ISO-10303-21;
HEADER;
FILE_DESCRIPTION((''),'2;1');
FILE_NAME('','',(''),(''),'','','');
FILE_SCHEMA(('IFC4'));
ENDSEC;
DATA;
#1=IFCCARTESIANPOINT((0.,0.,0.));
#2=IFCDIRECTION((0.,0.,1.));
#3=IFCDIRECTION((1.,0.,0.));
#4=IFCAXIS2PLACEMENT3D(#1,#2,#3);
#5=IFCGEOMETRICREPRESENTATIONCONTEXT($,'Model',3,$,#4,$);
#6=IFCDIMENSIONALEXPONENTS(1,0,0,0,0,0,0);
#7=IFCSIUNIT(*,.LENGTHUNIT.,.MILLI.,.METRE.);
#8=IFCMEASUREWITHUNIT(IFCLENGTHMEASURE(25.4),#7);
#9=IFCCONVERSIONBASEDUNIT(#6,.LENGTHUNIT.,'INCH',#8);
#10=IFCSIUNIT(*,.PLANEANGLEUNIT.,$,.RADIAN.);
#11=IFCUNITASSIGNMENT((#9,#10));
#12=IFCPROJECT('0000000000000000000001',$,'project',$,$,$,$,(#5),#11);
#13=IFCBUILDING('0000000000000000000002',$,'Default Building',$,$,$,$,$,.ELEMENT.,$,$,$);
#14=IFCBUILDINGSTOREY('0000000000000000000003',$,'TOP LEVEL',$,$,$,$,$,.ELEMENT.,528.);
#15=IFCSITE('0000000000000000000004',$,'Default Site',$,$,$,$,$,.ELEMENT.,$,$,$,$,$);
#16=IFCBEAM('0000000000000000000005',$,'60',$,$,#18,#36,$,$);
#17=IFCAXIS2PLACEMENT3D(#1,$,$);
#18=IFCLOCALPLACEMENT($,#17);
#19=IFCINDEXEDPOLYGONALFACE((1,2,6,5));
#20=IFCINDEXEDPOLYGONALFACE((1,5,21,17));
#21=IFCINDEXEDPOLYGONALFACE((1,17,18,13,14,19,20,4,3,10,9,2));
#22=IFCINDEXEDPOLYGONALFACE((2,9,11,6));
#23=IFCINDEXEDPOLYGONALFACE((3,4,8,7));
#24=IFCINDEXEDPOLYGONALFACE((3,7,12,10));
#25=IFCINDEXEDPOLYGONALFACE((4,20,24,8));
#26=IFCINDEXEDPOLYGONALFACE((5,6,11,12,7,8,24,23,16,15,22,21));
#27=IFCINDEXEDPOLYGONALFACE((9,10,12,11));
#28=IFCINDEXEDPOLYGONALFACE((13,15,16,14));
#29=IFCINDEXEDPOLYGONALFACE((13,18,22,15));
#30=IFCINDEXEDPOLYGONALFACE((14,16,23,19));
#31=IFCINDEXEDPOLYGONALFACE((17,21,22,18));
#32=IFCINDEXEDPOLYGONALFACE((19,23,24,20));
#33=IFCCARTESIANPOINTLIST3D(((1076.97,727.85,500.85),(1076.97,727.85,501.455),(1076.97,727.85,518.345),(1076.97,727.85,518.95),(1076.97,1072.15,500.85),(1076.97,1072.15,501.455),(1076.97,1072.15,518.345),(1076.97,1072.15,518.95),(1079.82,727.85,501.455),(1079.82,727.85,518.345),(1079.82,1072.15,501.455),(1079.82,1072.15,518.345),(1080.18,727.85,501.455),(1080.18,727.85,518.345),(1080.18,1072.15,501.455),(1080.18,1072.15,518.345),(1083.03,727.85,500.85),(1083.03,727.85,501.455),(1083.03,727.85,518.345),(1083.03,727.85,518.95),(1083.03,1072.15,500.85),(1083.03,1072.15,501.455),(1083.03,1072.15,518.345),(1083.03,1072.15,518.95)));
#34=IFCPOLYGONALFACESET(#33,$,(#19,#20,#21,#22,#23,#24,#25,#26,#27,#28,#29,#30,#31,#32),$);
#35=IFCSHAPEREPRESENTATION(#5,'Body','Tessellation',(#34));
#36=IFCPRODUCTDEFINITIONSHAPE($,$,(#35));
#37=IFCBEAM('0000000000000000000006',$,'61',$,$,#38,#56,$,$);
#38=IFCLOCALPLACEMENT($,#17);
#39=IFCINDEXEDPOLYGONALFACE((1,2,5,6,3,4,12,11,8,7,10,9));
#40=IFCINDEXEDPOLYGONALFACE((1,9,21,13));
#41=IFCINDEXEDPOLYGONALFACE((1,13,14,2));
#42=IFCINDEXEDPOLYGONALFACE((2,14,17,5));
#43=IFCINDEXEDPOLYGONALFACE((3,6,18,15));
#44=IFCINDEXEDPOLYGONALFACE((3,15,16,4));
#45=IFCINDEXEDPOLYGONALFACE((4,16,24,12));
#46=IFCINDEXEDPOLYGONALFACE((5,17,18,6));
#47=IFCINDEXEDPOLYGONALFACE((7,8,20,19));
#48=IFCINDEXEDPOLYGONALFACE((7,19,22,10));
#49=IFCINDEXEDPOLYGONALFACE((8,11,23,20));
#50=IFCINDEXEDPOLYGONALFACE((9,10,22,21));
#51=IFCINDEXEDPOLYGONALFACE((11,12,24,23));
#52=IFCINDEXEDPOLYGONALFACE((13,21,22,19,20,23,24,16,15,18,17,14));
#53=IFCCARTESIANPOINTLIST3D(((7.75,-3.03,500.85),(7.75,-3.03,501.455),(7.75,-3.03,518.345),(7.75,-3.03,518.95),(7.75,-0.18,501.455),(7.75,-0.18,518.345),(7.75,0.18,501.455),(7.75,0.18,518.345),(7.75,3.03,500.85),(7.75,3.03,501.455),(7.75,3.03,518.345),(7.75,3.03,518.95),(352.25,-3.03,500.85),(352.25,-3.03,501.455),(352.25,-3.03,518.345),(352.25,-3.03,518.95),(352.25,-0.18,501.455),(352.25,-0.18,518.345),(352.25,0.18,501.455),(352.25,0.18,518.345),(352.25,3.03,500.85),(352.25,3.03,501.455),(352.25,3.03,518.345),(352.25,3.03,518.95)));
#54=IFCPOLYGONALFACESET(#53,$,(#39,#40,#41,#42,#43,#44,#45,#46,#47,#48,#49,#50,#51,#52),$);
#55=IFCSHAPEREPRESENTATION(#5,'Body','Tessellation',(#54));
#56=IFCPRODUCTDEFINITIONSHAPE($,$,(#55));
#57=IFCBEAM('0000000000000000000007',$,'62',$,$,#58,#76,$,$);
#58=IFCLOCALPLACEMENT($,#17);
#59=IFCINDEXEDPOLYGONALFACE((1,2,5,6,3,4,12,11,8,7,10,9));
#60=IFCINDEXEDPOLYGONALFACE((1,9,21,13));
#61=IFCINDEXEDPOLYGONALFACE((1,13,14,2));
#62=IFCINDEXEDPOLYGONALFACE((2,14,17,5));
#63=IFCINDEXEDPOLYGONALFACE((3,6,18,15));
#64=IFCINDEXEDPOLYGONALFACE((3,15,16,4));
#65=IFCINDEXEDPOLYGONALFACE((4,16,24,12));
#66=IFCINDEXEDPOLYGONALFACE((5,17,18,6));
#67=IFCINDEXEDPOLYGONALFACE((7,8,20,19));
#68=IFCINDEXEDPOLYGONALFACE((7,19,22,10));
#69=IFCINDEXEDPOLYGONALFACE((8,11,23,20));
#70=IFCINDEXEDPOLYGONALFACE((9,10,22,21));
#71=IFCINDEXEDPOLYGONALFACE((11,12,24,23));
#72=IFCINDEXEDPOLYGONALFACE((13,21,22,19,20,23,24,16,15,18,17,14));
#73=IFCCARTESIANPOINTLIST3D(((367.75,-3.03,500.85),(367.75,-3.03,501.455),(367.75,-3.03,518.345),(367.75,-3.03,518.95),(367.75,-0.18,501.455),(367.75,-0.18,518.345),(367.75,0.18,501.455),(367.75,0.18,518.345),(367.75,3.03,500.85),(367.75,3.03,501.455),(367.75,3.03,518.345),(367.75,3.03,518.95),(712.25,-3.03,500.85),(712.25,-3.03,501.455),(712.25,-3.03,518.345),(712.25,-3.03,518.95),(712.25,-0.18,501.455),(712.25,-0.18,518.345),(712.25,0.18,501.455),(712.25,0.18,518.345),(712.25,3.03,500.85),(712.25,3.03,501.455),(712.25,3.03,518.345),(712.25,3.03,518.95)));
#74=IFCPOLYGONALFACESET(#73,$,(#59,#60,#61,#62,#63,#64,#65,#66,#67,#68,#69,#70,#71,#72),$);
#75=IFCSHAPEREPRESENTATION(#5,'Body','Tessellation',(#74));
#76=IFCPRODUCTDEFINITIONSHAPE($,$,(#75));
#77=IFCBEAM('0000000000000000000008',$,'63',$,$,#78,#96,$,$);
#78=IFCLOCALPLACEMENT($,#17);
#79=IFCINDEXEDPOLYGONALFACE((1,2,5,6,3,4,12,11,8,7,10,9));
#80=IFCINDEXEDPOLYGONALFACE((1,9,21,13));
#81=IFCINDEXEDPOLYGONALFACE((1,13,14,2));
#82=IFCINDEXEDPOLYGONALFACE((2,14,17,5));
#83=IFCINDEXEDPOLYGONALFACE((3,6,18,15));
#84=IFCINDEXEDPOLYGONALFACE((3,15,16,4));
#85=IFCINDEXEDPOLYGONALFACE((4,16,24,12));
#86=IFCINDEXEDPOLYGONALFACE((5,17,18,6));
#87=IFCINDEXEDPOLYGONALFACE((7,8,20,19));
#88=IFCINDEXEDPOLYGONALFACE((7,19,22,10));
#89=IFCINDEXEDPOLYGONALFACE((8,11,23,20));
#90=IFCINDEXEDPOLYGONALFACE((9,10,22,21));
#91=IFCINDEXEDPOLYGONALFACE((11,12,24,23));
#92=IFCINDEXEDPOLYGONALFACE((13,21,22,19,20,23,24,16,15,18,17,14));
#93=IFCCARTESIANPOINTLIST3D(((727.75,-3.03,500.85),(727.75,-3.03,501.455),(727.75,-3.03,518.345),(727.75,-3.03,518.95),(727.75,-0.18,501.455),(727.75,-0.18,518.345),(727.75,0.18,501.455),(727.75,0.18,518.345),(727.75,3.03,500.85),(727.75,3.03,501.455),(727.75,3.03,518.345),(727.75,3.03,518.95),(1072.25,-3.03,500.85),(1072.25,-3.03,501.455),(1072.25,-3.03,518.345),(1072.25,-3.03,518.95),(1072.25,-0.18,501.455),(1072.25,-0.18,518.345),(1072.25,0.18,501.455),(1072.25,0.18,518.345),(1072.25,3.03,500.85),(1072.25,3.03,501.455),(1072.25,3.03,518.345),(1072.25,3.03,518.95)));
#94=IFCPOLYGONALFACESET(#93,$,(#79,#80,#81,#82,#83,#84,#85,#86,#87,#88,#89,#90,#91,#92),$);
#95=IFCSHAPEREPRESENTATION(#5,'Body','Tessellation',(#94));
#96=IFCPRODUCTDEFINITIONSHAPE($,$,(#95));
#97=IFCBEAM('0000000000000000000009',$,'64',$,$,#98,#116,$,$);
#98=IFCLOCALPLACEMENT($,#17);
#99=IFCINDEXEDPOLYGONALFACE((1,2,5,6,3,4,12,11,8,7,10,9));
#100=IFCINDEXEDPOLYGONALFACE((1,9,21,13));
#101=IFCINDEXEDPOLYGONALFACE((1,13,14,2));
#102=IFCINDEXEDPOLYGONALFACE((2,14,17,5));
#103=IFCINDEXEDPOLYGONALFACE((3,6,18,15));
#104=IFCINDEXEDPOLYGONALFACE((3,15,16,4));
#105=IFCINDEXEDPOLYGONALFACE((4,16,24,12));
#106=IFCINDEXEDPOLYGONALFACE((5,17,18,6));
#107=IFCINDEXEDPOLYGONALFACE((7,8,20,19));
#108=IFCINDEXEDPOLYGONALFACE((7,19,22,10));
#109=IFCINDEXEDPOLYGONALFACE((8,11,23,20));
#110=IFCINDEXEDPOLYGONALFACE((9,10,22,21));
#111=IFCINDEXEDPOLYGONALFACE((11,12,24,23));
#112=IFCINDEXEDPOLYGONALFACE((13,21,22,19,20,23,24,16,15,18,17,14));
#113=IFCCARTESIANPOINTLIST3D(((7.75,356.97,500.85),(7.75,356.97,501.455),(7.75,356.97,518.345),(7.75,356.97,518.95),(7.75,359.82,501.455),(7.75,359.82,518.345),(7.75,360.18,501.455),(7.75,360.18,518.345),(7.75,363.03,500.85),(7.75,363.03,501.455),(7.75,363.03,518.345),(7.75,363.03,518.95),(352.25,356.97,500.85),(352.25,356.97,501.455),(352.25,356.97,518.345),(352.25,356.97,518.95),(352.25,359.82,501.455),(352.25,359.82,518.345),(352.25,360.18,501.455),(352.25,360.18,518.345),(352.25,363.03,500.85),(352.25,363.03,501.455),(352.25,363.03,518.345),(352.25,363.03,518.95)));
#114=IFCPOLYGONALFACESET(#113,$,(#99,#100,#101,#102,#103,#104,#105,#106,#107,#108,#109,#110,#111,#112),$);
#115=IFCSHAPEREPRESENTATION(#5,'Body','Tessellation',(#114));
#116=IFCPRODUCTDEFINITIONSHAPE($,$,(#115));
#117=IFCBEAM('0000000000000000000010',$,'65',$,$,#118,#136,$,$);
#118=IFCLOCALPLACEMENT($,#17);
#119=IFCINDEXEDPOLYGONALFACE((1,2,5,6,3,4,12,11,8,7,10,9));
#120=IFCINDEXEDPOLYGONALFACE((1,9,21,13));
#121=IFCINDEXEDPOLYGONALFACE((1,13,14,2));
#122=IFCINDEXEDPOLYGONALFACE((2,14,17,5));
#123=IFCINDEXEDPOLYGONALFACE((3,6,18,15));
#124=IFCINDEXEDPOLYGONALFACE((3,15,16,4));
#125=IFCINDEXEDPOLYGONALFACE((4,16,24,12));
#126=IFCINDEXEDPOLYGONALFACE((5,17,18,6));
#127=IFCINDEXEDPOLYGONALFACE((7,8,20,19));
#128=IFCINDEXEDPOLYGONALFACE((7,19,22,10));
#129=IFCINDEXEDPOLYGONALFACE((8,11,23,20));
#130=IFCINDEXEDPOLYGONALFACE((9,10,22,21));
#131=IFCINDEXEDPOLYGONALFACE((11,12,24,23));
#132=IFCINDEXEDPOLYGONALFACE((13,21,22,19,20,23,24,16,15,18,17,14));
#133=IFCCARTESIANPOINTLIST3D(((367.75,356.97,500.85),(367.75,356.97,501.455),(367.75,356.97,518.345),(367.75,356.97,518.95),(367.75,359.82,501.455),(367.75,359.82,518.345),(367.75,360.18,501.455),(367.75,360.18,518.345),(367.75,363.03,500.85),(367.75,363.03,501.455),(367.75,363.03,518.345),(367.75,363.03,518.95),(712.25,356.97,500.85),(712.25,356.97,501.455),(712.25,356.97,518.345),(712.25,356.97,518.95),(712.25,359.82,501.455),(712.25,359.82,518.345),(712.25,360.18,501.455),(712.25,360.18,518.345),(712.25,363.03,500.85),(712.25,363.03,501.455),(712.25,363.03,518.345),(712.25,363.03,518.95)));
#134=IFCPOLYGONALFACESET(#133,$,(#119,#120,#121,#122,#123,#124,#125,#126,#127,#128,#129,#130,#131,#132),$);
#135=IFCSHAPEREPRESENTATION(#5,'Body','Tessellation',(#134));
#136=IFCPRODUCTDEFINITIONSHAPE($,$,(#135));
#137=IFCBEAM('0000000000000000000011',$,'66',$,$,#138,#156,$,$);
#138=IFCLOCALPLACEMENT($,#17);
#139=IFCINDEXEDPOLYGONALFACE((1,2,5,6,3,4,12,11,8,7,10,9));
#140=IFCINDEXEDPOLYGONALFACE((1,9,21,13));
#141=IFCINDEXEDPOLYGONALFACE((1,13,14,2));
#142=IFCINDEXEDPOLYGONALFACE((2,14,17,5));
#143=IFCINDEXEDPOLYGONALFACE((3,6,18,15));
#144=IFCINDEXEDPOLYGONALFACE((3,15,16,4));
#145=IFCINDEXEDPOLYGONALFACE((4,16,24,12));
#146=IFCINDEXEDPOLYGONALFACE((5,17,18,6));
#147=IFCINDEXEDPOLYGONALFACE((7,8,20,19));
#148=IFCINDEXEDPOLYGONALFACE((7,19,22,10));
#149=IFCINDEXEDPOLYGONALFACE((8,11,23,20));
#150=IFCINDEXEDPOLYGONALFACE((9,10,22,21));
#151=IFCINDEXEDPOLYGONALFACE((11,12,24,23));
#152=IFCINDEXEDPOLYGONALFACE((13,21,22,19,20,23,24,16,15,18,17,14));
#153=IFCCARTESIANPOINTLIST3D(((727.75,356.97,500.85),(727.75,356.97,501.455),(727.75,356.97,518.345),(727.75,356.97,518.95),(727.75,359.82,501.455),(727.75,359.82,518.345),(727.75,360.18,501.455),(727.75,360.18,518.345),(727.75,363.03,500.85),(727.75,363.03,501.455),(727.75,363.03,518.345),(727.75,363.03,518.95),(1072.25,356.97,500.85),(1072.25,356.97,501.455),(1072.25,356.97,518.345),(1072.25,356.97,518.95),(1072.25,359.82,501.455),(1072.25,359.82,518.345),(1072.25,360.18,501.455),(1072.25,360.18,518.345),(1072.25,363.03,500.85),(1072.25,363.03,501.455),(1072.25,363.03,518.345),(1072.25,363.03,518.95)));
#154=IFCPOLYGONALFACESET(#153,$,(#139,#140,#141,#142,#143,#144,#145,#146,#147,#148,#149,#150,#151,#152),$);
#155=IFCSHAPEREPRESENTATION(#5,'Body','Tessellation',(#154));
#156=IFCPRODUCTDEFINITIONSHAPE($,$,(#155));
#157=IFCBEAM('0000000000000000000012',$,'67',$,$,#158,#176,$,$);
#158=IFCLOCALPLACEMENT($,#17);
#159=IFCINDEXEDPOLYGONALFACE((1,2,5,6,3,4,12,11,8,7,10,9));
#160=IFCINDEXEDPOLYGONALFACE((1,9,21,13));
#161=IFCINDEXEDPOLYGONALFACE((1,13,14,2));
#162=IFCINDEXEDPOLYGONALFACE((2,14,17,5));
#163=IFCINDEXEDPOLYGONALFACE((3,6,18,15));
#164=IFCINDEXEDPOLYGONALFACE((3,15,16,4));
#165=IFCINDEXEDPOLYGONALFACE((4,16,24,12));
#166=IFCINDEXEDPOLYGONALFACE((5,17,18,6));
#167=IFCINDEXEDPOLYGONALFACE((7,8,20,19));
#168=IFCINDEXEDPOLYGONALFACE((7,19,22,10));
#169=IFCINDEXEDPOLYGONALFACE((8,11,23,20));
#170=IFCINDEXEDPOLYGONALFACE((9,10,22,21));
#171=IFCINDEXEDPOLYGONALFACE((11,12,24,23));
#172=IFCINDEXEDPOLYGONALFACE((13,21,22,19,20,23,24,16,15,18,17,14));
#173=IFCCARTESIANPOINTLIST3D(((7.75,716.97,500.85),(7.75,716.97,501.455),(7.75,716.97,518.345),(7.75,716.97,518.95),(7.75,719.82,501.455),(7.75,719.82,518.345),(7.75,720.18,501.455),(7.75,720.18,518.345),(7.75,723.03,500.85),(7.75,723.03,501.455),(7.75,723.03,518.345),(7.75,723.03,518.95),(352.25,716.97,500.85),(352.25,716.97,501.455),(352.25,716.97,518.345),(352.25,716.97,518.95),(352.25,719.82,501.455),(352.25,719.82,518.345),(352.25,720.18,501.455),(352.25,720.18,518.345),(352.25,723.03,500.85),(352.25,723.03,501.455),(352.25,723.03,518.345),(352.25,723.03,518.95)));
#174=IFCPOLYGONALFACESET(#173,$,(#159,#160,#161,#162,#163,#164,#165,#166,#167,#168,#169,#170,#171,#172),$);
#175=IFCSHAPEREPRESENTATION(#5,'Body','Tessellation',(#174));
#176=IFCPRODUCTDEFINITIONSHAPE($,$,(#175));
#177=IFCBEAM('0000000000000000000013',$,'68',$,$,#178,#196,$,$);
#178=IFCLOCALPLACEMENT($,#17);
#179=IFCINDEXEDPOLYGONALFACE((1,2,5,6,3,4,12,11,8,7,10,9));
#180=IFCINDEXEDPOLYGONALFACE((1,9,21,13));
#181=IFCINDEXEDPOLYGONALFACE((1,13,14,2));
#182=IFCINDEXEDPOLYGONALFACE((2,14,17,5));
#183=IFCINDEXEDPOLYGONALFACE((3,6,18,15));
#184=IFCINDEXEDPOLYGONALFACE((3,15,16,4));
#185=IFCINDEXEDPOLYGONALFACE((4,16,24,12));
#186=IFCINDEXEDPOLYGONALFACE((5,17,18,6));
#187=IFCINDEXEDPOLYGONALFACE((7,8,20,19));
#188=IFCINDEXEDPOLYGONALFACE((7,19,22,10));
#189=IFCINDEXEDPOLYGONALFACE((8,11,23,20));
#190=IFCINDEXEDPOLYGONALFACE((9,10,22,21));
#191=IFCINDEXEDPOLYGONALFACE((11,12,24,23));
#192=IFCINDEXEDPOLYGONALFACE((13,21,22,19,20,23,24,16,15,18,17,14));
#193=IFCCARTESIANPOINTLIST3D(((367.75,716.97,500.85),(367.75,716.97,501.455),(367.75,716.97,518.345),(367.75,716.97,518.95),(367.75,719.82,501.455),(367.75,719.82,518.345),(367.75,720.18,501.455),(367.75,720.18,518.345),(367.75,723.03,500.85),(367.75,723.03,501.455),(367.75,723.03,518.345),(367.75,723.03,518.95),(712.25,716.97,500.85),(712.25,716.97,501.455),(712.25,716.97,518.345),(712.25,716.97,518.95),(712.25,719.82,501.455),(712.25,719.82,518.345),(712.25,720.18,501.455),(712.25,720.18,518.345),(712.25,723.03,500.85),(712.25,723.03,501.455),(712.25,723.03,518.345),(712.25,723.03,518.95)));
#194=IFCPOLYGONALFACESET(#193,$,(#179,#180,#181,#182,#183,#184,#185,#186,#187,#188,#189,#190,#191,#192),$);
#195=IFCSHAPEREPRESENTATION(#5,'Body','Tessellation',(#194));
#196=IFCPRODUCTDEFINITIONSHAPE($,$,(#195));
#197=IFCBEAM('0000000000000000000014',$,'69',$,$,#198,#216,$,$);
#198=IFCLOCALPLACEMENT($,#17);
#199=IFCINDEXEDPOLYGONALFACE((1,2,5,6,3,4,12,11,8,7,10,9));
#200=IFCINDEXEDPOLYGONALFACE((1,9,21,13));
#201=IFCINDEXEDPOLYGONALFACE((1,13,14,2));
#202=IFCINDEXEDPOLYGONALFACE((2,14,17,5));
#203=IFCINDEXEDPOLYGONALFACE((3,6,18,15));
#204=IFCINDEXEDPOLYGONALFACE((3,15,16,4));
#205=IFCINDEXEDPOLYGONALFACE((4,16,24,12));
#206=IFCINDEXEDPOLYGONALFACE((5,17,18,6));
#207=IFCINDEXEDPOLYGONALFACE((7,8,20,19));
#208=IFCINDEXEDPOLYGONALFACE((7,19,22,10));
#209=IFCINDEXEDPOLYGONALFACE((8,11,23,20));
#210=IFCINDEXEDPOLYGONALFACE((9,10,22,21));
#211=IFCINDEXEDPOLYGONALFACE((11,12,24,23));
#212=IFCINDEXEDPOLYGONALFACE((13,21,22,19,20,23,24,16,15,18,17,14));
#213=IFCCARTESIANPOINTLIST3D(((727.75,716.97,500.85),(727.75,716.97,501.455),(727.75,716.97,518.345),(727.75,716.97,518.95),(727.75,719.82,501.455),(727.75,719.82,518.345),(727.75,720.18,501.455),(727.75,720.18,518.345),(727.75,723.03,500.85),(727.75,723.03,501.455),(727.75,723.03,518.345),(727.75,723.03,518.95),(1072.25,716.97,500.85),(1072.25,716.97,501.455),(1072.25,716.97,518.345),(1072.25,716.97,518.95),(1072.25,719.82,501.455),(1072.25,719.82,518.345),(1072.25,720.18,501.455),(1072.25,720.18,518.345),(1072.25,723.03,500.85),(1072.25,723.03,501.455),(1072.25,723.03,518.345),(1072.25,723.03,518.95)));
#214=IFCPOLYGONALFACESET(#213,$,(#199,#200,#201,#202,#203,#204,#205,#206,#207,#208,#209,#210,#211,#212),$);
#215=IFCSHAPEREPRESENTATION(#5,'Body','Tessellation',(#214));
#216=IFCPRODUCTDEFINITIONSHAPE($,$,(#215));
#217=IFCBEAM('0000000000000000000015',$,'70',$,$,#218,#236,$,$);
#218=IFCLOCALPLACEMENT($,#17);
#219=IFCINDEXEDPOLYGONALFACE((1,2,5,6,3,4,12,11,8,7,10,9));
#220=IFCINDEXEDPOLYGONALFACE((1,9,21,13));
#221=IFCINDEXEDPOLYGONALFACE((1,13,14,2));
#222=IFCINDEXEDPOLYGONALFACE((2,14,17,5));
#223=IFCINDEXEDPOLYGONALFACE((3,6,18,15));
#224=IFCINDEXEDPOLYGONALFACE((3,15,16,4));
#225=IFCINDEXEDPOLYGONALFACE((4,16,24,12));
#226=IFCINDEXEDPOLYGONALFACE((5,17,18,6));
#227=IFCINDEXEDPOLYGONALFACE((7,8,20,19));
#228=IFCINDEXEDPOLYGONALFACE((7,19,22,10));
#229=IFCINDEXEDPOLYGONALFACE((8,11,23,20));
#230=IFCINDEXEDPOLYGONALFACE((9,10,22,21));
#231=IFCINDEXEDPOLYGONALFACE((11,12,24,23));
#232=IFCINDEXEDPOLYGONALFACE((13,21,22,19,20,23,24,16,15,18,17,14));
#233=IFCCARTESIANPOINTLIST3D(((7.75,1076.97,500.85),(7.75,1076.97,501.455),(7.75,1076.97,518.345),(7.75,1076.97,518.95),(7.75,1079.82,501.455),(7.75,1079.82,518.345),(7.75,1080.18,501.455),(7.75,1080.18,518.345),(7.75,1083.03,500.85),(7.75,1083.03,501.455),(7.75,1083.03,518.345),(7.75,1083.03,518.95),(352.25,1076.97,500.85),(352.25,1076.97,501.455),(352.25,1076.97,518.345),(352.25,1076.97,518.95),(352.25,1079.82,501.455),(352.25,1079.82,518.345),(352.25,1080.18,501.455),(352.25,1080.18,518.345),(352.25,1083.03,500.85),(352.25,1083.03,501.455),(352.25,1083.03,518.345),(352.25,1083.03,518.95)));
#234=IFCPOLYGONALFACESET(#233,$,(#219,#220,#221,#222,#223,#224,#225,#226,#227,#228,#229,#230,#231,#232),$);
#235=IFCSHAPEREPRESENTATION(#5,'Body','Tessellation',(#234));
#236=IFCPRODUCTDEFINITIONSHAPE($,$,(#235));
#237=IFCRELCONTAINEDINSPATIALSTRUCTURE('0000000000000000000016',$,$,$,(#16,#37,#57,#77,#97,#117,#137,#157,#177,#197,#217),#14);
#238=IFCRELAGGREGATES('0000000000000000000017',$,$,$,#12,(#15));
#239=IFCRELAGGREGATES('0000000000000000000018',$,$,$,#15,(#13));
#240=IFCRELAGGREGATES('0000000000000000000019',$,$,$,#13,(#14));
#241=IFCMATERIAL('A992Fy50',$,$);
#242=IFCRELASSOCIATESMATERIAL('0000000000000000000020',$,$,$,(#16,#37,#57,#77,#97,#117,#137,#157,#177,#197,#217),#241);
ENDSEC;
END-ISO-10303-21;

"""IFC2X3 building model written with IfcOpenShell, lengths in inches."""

from ifc_helpers import new_model, entity, si_unit, converted_unit, frame, origin_with_axes, origin_2d_with_axis, place, context, project, spatial, i_section, transform_2d, derived_profile, extrude, material, element, save


model = new_model("IFC2X3")

# Units and contexts
model_context = context("Model", 3, world=origin_with_axes())
ifc_project = project(units=[converted_unit("LENGTHUNIT", "INCH", entity("IfcLengthMeasure", 25.4), si_unit("LENGTHUNIT", "METRE", prefix="MILLI"), dimensions=[1, 0, 0, 0, 0, 0, 0]), si_unit("PLANEANGLEUNIT", "RADIAN")], contexts=[model_context])

# Site, building, storey
site = spatial("IfcSite", under=ifc_project, Name="Default Site", CompositionType="ELEMENT")
building = spatial("IfcBuilding", under=site, Name="Default Building", CompositionType="ELEMENT")
storey = spatial("IfcBuildingStorey", under=building, Name="TOP LEVEL", CompositionType="ELEMENT", Elevation=528.0)

# Beams
ifc_material = material(Name="A992Fy50")
for number, where, z_axis, x_axis, name in (
    (1, (1080.0, 727.85, 528.0), (0.0, 1.0, 0.0), (-1.0, 0.0, 0.0), "60"),
):
    element("IfcBeam", number, at=place(None, frame(where, z_axis=z_axis, x_axis=x_axis)), inside=storey, material=ifc_material, Name=name, context=model_context, shape_type="SweptSolid", body=[
        extrude(derived_profile(i_section(OverallWidth=6.06, OverallDepth=18.1, WebThickness=0.36, FlangeThickness=0.605, at=origin_2d_with_axis()), transform_2d((0.0, -9.05))), origin_with_axes(), (0.0, 0.0, 1.0), 344.3),
    ])
for number, where, z_axis, x_axis, name in (
    (2, (7.75, 0.0, 528.0), (1.0, 0.0, 0.0), (0.0, 1.0, 0.0), "61"),
    (3, (367.75, 0.0, 528.0), (1.0, 0.0, 0.0), (0.0, 1.0, 0.0), "62"),
    (4, (727.75, 0.0, 528.0), (1.0, 0.0, 0.0), (0.0, 1.0, 0.0), "63"),
    (5, (7.75, 360.0, 528.0), (1.0, 0.0, 0.0), (0.0, 1.0, 0.0), "64"),
    (6, (367.75, 360.0, 528.0), (1.0, 0.0, 0.0), (0.0, 1.0, 0.0), "65"),
    (7, (727.75, 360.0, 528.0), (1.0, 0.0, 0.0), (0.0, 1.0, 0.0), "66"),
    (8, (7.75, 720.0, 528.0), (1.0, 0.0, 0.0), (0.0, 1.0, 0.0), "67"),
    (9, (367.75, 720.0, 528.0), (1.0, 0.0, 0.0), (0.0, 1.0, 0.0), "68"),
    (10, (727.75, 720.0, 528.0), (1.0, 0.0, 0.0), (0.0, 1.0, 0.0), "69"),
    (11, (7.75, 1080.0, 528.0), (1.0, 0.0, 0.0), (0.0, 1.0, 0.0), "70"),
):
    element("IfcBeam", number, at=place(None, frame(where, z_axis=z_axis, x_axis=x_axis)), inside=storey, material=ifc_material, Name=name, context=model_context, shape_type="SweptSolid", body=[
        extrude(derived_profile(i_section(OverallWidth=6.06, OverallDepth=18.1, WebThickness=0.36, FlangeThickness=0.605, at=origin_2d_with_axis()), transform_2d((0.0, -9.05))), origin_with_axes(), (0.0, 0.0, 1.0), 344.5),
    ])

save(model, "model.ifc")
